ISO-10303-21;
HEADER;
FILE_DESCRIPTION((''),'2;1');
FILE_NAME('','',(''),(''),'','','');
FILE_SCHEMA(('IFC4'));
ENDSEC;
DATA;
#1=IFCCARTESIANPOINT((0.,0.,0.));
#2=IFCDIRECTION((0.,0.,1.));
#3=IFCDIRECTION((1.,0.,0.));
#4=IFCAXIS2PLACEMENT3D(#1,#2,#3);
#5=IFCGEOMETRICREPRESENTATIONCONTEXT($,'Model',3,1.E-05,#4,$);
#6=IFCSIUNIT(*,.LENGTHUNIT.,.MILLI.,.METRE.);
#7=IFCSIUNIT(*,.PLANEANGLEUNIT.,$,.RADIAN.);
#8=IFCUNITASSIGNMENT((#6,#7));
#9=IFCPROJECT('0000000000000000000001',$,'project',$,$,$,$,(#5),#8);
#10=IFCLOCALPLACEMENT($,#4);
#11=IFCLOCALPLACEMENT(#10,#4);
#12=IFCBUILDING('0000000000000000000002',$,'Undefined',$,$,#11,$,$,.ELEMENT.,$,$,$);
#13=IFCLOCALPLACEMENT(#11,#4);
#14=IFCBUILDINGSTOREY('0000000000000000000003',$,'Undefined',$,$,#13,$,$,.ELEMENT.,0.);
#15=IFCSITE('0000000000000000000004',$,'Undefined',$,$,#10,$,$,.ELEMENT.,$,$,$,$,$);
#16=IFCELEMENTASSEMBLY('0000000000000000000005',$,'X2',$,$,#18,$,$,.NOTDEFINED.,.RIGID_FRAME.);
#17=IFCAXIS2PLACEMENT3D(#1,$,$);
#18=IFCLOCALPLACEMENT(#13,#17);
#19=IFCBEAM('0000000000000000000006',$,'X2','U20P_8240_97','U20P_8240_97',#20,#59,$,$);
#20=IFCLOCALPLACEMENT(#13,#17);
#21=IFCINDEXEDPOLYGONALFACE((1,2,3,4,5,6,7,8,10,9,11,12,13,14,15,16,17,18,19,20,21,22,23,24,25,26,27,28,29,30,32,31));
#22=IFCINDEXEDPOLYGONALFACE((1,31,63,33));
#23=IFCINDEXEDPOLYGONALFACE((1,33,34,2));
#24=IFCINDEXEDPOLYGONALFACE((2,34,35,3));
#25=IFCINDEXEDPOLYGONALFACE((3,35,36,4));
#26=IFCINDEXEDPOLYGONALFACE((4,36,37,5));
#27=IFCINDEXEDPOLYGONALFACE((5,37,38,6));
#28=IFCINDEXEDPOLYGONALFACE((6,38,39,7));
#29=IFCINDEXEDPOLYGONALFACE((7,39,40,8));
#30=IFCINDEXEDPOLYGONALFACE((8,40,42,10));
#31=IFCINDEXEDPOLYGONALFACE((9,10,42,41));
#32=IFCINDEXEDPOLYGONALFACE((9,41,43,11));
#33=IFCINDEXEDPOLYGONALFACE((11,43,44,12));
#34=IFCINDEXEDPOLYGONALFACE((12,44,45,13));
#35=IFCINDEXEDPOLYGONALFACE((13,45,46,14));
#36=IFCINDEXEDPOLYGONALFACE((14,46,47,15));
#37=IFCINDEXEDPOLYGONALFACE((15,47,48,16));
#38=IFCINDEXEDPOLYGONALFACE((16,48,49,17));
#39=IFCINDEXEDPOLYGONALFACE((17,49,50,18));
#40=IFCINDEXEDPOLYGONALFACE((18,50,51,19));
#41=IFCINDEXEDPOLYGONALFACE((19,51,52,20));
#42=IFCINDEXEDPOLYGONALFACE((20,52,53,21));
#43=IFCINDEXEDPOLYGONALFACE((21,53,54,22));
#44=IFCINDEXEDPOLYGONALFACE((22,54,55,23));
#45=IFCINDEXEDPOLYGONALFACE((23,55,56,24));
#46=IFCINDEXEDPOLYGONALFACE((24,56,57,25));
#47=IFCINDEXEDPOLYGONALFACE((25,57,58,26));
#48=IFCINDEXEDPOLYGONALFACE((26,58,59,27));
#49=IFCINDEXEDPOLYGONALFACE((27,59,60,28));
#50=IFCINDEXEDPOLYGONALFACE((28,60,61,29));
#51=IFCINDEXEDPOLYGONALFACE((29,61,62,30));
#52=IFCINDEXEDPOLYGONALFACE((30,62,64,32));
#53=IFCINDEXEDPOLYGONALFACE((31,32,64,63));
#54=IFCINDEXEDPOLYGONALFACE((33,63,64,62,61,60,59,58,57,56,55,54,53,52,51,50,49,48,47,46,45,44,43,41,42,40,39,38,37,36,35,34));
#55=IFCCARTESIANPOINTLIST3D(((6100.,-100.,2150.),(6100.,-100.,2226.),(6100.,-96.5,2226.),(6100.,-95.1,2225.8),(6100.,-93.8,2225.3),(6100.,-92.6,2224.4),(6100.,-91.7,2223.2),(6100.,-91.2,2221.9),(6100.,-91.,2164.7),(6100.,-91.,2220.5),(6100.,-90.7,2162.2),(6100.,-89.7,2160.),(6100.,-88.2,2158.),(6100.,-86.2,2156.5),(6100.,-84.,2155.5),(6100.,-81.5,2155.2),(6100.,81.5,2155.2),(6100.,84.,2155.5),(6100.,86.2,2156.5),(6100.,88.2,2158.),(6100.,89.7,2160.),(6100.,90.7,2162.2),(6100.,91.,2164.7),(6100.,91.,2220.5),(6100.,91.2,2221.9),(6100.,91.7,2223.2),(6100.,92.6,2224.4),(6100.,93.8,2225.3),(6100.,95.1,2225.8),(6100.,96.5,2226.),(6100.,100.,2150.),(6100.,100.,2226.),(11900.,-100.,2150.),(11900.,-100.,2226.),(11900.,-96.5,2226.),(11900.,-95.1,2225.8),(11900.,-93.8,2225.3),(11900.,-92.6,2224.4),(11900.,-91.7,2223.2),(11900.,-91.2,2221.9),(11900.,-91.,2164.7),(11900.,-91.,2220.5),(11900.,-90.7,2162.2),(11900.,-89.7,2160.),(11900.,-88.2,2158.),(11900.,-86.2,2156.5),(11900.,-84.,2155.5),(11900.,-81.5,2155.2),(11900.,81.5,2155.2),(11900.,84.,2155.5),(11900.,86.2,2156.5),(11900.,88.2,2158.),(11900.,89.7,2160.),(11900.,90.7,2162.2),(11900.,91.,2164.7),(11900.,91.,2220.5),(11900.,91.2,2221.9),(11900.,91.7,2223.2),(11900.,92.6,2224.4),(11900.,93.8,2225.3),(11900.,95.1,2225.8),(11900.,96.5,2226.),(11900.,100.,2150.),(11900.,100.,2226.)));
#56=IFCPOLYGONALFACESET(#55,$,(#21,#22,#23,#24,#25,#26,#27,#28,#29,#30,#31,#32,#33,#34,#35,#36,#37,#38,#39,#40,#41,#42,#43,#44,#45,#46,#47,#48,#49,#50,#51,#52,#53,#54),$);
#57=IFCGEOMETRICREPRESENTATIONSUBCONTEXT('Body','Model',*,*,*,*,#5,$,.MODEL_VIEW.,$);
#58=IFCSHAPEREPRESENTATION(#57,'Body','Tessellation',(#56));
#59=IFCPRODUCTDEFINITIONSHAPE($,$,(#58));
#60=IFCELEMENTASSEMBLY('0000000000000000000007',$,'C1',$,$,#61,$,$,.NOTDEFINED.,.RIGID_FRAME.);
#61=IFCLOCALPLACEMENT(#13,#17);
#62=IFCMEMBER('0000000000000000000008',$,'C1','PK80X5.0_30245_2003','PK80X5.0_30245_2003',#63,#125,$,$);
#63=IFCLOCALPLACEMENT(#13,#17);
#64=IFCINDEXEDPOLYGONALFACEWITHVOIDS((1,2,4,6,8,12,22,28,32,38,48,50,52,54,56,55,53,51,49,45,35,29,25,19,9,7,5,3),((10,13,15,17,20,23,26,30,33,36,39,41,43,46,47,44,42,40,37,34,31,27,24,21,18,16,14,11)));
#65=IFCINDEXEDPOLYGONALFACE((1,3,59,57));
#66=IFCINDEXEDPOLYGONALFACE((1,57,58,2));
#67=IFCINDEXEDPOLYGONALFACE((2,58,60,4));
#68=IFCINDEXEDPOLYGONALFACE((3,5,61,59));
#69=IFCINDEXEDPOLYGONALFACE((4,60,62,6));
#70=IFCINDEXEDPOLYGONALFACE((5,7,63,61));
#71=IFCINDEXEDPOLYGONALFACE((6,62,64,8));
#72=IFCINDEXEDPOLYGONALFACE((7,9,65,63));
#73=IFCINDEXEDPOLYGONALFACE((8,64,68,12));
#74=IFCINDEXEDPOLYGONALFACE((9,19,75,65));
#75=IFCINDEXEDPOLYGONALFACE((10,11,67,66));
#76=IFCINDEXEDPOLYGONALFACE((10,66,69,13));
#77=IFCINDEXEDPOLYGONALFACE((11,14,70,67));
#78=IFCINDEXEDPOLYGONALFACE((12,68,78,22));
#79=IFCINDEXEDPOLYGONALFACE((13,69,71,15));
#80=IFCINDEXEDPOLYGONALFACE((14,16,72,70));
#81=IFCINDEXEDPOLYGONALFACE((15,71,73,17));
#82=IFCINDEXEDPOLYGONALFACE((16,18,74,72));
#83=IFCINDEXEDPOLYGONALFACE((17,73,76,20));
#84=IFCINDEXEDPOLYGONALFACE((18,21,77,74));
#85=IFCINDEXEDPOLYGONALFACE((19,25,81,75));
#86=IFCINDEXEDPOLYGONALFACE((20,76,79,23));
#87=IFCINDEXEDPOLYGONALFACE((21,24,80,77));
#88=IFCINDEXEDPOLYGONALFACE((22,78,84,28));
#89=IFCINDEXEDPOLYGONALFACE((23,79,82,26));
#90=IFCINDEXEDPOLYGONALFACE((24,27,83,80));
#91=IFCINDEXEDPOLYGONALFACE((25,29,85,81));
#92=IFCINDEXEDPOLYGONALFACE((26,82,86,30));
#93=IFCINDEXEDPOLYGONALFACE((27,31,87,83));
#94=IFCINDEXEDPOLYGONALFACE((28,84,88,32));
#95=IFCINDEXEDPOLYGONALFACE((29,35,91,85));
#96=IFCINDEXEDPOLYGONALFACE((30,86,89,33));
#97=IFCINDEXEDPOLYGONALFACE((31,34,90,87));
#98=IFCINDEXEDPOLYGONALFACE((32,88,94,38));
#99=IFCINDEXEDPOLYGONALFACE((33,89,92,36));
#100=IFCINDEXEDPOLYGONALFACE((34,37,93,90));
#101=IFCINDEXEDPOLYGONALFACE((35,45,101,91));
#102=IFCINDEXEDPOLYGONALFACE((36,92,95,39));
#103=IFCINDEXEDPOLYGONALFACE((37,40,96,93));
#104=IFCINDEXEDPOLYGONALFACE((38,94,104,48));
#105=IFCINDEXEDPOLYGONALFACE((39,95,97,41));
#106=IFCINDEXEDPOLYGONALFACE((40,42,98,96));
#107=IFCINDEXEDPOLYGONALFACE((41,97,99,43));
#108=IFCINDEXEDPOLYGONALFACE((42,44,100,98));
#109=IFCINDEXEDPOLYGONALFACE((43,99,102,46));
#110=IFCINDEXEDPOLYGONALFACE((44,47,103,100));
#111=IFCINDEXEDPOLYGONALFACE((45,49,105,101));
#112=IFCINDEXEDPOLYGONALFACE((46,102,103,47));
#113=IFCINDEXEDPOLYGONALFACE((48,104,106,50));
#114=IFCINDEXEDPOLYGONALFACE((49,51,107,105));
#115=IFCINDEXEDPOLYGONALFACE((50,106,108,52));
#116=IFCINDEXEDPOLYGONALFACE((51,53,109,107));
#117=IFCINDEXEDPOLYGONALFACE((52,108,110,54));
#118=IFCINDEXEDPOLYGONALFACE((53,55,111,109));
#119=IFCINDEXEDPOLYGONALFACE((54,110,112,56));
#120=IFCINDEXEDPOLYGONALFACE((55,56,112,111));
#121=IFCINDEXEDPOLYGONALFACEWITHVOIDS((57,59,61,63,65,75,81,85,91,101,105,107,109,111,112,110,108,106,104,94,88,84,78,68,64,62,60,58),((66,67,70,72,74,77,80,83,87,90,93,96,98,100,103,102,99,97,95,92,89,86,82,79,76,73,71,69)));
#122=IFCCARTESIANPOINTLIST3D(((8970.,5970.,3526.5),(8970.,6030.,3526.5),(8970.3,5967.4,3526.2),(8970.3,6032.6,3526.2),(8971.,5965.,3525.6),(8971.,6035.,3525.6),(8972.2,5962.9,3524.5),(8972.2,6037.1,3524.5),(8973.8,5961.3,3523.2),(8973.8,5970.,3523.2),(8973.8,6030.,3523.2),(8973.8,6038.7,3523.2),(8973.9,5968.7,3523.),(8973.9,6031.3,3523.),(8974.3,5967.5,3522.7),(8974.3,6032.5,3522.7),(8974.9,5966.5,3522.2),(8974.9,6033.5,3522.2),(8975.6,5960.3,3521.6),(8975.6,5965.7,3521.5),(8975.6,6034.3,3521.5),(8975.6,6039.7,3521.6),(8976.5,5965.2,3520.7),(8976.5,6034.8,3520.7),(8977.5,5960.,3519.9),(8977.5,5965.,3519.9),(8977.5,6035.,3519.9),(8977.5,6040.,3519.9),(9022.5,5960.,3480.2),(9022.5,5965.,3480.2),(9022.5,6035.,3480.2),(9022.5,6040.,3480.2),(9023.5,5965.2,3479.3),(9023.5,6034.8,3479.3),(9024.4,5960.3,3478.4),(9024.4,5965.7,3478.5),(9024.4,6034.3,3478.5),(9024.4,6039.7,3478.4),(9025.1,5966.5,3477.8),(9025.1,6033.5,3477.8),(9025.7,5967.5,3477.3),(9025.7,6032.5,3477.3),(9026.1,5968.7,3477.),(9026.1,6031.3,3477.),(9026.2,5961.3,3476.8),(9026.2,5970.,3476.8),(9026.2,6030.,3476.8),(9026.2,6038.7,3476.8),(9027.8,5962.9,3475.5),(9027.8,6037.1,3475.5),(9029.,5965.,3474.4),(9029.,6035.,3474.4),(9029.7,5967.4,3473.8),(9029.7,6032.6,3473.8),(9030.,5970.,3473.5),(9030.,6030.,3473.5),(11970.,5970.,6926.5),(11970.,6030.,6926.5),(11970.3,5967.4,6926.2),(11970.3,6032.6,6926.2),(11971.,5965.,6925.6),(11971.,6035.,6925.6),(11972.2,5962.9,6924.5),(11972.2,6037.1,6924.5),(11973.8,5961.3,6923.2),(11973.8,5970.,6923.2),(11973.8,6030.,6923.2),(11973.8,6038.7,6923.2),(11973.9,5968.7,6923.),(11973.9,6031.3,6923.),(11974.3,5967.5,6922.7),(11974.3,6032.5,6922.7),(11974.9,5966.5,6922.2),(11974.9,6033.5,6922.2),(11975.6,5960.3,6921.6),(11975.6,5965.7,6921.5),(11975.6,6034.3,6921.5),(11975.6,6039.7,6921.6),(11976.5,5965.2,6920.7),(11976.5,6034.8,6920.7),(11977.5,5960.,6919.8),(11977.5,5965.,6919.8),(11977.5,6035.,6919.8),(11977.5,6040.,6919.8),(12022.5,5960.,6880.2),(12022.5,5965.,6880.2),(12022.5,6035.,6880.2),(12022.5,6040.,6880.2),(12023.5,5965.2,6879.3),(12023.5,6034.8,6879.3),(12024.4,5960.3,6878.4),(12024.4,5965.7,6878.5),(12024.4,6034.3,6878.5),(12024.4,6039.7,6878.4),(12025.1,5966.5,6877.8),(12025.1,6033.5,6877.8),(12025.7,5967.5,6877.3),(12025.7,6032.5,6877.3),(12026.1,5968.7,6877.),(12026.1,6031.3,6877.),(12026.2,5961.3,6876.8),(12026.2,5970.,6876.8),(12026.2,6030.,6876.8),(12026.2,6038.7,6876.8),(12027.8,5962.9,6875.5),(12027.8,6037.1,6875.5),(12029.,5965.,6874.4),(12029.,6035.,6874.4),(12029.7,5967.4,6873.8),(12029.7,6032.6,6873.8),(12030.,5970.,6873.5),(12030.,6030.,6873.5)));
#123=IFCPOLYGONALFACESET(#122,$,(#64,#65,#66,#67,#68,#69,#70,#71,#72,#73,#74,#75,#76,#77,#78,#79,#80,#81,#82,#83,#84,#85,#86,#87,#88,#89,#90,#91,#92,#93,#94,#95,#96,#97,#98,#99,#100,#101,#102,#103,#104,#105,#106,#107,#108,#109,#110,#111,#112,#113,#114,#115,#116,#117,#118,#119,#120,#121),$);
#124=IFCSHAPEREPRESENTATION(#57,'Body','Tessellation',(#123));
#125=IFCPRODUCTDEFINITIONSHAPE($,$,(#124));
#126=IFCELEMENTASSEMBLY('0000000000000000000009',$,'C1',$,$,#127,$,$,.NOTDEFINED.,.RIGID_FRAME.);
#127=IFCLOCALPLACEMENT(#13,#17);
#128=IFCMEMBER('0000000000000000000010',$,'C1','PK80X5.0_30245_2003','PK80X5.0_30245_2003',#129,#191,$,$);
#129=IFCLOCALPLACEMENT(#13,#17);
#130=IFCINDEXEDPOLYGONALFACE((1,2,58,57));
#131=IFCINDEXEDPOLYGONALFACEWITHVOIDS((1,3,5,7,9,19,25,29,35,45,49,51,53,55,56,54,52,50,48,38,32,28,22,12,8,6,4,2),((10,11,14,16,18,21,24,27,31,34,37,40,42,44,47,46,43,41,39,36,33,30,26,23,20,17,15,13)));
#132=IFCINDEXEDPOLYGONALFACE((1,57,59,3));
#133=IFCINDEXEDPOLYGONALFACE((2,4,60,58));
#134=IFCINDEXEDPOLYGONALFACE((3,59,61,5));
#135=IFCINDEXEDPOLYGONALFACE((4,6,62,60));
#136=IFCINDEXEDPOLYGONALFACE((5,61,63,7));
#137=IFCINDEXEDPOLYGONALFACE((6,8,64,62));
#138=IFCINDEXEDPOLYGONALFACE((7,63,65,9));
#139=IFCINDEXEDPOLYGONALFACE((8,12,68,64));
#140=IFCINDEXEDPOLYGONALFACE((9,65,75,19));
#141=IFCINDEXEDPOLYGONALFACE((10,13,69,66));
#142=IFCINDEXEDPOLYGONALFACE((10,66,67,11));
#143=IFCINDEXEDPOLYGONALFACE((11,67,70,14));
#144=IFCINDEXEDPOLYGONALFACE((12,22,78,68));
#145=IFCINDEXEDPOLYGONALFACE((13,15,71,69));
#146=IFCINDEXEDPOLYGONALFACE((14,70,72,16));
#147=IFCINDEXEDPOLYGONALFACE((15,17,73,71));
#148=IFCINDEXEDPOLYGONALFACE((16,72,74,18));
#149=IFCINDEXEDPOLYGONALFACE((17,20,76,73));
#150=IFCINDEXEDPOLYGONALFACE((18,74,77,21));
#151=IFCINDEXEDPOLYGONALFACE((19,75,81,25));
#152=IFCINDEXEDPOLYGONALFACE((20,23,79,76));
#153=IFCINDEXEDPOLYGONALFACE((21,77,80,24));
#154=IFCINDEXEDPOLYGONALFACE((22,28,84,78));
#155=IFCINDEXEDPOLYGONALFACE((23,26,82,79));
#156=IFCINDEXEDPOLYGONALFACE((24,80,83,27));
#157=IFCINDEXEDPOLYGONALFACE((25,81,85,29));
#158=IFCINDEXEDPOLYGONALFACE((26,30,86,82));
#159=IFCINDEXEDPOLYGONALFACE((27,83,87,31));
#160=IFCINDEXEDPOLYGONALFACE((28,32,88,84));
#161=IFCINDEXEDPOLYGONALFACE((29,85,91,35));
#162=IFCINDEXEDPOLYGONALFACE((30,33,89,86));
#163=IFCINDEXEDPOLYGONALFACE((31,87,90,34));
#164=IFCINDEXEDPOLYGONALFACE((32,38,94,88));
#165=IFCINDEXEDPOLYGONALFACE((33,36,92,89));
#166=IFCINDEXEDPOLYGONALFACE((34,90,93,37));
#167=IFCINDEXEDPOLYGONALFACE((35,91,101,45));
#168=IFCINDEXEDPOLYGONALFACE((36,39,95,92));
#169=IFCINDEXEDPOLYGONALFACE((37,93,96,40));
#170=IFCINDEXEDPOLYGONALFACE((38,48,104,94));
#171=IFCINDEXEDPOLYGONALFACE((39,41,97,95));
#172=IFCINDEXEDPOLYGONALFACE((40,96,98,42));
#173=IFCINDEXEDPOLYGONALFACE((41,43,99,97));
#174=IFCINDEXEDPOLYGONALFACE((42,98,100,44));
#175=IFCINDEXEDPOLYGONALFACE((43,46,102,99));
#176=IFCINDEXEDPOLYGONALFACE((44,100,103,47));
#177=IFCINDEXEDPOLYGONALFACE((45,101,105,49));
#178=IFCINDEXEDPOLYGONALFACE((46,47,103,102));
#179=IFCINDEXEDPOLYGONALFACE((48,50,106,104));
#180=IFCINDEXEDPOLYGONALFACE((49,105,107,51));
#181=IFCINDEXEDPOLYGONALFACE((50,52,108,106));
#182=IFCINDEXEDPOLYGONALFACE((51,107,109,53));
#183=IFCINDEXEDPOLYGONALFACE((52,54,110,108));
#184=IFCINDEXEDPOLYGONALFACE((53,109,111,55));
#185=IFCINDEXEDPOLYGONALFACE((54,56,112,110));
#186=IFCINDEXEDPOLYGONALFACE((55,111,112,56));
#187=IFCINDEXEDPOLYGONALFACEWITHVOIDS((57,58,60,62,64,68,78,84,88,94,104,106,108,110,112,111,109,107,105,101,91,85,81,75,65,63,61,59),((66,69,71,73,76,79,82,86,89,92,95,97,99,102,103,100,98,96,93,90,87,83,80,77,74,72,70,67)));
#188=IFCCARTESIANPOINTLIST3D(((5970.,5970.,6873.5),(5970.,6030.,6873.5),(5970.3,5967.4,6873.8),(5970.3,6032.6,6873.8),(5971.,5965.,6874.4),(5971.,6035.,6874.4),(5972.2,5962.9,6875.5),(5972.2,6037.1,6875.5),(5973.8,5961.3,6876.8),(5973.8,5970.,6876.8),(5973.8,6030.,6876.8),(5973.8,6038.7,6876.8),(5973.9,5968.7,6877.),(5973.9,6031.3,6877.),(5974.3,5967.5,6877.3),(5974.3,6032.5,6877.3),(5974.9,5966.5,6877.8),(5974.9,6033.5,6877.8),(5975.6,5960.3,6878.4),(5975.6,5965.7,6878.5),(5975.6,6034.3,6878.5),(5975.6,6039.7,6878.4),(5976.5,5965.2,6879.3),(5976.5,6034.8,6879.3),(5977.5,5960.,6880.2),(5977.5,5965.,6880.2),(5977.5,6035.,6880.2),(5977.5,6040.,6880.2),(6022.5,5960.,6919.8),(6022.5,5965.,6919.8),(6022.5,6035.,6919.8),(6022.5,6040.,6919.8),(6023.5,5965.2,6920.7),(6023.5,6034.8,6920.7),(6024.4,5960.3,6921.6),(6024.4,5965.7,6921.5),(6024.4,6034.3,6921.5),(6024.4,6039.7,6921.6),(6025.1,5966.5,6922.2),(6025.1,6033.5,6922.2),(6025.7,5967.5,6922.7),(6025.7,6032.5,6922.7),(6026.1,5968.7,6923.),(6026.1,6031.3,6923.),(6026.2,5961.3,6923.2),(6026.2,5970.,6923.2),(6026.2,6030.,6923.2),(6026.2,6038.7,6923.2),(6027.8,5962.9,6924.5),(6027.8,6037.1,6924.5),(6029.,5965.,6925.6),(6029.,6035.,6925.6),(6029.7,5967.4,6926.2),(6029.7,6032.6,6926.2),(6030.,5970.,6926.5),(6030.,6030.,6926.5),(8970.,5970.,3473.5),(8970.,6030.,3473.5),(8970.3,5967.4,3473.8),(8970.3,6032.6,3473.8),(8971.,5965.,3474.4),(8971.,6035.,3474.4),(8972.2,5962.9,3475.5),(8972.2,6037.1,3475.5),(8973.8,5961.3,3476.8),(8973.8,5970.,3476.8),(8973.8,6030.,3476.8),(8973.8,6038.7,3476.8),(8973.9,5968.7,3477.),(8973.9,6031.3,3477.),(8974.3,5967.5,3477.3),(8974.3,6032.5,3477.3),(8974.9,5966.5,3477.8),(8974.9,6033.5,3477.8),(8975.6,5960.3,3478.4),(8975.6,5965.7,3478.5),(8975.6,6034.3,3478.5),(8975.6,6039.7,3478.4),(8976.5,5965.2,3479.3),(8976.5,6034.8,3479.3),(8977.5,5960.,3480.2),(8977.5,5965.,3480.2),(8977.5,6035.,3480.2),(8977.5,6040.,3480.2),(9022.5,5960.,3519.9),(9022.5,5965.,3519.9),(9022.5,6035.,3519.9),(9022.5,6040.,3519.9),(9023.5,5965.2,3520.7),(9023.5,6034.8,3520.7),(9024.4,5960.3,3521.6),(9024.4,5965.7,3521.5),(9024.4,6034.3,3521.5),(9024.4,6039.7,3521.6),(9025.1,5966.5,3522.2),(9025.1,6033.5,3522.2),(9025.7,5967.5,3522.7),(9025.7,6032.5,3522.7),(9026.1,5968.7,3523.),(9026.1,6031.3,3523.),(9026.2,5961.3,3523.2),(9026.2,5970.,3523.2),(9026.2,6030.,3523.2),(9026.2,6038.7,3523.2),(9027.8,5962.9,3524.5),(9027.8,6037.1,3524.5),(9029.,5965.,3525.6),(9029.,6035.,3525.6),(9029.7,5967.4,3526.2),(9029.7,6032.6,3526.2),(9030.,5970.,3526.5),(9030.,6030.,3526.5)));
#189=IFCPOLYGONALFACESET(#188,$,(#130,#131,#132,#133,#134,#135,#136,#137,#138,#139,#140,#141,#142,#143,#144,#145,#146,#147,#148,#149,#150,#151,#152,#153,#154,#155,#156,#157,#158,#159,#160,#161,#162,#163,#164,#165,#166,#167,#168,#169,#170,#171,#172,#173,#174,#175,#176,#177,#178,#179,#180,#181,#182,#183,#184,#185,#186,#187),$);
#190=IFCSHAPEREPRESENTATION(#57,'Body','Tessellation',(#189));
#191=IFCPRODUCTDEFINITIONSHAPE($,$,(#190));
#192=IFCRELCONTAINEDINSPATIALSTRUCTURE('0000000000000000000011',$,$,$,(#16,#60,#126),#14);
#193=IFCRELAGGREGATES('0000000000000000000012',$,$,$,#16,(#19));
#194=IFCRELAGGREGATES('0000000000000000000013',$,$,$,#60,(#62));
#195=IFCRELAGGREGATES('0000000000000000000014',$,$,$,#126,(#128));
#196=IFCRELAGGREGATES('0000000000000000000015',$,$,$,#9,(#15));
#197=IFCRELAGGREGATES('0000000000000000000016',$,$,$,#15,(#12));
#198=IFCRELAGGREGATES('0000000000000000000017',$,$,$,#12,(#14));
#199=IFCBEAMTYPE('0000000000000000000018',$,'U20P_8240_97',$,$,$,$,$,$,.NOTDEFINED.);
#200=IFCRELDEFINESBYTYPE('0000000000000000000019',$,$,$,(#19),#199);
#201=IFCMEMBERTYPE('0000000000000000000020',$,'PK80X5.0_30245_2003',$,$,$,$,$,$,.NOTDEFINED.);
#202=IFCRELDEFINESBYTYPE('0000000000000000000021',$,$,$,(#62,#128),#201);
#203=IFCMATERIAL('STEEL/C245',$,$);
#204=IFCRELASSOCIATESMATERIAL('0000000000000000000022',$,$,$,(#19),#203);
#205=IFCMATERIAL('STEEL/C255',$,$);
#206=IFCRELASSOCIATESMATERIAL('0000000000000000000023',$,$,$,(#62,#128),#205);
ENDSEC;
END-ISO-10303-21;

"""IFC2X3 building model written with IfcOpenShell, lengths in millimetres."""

from ifc_helpers import new_model, si_unit, frame, origin_with_axes, origin_2d_with_axis, place, context, subcontext, project, spatial, hollow_rectangle, u_section, extrude, material, type_object, element, aggregate, save


model = new_model("IFC2X3")

# Units and contexts
model_context = context("Model", 3, precision=1e-05, world=origin_with_axes())
body_context = subcontext(model_context, "Body", "Model", "MODEL_VIEW")
ifc_project = project(units=[si_unit("LENGTHUNIT", "METRE", prefix="MILLI"), si_unit("PLANEANGLEUNIT", "RADIAN")], contexts=[model_context])

# Site, building, storey
site_placement = place(None, origin_with_axes())
site = spatial("IfcSite", under=ifc_project, at=site_placement, Name="Undefined", CompositionType="ELEMENT")
building_placement = place(site_placement, origin_with_axes())
building = spatial("IfcBuilding", under=site, at=building_placement, Name="Undefined", CompositionType="ELEMENT")
storey_placement = place(building_placement, origin_with_axes())
storey = spatial("IfcBuildingStorey", under=building, at=storey_placement, Name="Undefined", CompositionType="ELEMENT", Elevation=0.0)

# Element assembly, beam
ifc_material_1 = material(Name="STEEL/C255")
ifc_material_2 = material(Name="STEEL/C245")
assembly_1_placement = place(storey_placement, origin_with_axes())
assembly_1 = element("IfcElementAssembly", 1, at=assembly_1_placement, inside=storey, Name="X2", AssemblyPlace="NOTDEFINED", PredefinedType="RIGID_FRAME")
beam_type_1 = type_object("IfcBeamType", Name="U20P_8240_97", PredefinedType="NOTDEFINED")
beam_1_placement = place(assembly_1_placement, frame((6100.0, 0.0, 2188.0), z_axis=(0.0, 1.0, 0.0), x_axis=(1.0, 0.0, 0.0)))
beam_1 = element("IfcBeam", 2, at=beam_1_placement, type_object=beam_type_1, material=ifc_material_2, Name="X2", Description="U20P_8240_97", ObjectType="U20P_8240_97", context=body_context, shape_type="SweptSolid", body=[
    extrude(u_section(Depth=200.0, FlangeWidth=76.0, WebThickness=5.2, FlangeThickness=9.0, FilletRadius=9.5, EdgeRadius=5.5, at=origin_2d_with_axis()), frame((5800.0, 0.0, 0.0), z_axis=(-1.0, 0.0, 0.0), x_axis=(0.0, -1.0, 0.0)), (0.0, 0.0, 1.0), 5800.0),
])
aggregate(assembly_1, [beam_1])

# Element assemblies, members
assembly_2_placement = place(storey_placement, origin_with_axes())
assembly_2 = element("IfcElementAssembly", 3, at=assembly_2_placement, inside=storey, Name="C1", AssemblyPlace="NOTDEFINED", PredefinedType="RIGID_FRAME")
member_type = type_object("IfcMemberType", Name="PK80X5.0_30245_2003", PredefinedType="NOTDEFINED")
member_1_placement = place(assembly_2_placement, frame((9000.0, 6000.0, 3500.0), z_axis=(0.749838, 0.0, -0.661622), x_axis=(0.661622, 0.0, 0.749838)))
member_1 = element("IfcMember", 4, at=member_1_placement, type_object=member_type, material=ifc_material_1, Name="C1", Description="PK80X5.0_30245_2003", ObjectType="PK80X5.0_30245_2003", context=body_context, shape_type="SweptSolid", body=[
    extrude(hollow_rectangle(XDim=80.0, YDim=80.0, WallThickness=5.0, InnerFilletRadius=5.0, OuterFilletRadius=10.0, at=origin_2d_with_axis()), frame((4534.3, 0.0, 0.0), z_axis=(-1.0, 0.0, 0.0), x_axis=(0.0, -1.0, 0.0)), (0.0, 0.0, 1.0), 4534.3),
])
aggregate(assembly_2, [member_1])
assembly_3_placement = place(storey_placement, origin_with_axes())
assembly_3 = element("IfcElementAssembly", 5, at=assembly_3_placement, inside=storey, Name="C1", AssemblyPlace="NOTDEFINED", PredefinedType="RIGID_FRAME")
member_2_placement = place(assembly_3_placement, frame((9000.0, 6000.0, 3500.0), z_axis=(-0.749838, 0.0, -0.661622), x_axis=(-0.661622, 0.0, 0.749838)))
member_2 = element("IfcMember", 6, at=member_2_placement, type_object=member_type, material=ifc_material_1, Name="C1", Description="PK80X5.0_30245_2003", ObjectType="PK80X5.0_30245_2003", context=body_context, shape_type="SweptSolid", body=[
    extrude(hollow_rectangle(XDim=80.0, YDim=80.0, WallThickness=5.0, InnerFilletRadius=5.0, OuterFilletRadius=10.0, at=origin_2d_with_axis()), frame((4534.3, 0.0, 0.0), z_axis=(-1.0, 0.0, 0.0), x_axis=(0.0, -1.0, 0.0)), (0.0, 0.0, 1.0), 4534.3),
])
aggregate(assembly_3, [member_2])

save(model, "model.ifc")
